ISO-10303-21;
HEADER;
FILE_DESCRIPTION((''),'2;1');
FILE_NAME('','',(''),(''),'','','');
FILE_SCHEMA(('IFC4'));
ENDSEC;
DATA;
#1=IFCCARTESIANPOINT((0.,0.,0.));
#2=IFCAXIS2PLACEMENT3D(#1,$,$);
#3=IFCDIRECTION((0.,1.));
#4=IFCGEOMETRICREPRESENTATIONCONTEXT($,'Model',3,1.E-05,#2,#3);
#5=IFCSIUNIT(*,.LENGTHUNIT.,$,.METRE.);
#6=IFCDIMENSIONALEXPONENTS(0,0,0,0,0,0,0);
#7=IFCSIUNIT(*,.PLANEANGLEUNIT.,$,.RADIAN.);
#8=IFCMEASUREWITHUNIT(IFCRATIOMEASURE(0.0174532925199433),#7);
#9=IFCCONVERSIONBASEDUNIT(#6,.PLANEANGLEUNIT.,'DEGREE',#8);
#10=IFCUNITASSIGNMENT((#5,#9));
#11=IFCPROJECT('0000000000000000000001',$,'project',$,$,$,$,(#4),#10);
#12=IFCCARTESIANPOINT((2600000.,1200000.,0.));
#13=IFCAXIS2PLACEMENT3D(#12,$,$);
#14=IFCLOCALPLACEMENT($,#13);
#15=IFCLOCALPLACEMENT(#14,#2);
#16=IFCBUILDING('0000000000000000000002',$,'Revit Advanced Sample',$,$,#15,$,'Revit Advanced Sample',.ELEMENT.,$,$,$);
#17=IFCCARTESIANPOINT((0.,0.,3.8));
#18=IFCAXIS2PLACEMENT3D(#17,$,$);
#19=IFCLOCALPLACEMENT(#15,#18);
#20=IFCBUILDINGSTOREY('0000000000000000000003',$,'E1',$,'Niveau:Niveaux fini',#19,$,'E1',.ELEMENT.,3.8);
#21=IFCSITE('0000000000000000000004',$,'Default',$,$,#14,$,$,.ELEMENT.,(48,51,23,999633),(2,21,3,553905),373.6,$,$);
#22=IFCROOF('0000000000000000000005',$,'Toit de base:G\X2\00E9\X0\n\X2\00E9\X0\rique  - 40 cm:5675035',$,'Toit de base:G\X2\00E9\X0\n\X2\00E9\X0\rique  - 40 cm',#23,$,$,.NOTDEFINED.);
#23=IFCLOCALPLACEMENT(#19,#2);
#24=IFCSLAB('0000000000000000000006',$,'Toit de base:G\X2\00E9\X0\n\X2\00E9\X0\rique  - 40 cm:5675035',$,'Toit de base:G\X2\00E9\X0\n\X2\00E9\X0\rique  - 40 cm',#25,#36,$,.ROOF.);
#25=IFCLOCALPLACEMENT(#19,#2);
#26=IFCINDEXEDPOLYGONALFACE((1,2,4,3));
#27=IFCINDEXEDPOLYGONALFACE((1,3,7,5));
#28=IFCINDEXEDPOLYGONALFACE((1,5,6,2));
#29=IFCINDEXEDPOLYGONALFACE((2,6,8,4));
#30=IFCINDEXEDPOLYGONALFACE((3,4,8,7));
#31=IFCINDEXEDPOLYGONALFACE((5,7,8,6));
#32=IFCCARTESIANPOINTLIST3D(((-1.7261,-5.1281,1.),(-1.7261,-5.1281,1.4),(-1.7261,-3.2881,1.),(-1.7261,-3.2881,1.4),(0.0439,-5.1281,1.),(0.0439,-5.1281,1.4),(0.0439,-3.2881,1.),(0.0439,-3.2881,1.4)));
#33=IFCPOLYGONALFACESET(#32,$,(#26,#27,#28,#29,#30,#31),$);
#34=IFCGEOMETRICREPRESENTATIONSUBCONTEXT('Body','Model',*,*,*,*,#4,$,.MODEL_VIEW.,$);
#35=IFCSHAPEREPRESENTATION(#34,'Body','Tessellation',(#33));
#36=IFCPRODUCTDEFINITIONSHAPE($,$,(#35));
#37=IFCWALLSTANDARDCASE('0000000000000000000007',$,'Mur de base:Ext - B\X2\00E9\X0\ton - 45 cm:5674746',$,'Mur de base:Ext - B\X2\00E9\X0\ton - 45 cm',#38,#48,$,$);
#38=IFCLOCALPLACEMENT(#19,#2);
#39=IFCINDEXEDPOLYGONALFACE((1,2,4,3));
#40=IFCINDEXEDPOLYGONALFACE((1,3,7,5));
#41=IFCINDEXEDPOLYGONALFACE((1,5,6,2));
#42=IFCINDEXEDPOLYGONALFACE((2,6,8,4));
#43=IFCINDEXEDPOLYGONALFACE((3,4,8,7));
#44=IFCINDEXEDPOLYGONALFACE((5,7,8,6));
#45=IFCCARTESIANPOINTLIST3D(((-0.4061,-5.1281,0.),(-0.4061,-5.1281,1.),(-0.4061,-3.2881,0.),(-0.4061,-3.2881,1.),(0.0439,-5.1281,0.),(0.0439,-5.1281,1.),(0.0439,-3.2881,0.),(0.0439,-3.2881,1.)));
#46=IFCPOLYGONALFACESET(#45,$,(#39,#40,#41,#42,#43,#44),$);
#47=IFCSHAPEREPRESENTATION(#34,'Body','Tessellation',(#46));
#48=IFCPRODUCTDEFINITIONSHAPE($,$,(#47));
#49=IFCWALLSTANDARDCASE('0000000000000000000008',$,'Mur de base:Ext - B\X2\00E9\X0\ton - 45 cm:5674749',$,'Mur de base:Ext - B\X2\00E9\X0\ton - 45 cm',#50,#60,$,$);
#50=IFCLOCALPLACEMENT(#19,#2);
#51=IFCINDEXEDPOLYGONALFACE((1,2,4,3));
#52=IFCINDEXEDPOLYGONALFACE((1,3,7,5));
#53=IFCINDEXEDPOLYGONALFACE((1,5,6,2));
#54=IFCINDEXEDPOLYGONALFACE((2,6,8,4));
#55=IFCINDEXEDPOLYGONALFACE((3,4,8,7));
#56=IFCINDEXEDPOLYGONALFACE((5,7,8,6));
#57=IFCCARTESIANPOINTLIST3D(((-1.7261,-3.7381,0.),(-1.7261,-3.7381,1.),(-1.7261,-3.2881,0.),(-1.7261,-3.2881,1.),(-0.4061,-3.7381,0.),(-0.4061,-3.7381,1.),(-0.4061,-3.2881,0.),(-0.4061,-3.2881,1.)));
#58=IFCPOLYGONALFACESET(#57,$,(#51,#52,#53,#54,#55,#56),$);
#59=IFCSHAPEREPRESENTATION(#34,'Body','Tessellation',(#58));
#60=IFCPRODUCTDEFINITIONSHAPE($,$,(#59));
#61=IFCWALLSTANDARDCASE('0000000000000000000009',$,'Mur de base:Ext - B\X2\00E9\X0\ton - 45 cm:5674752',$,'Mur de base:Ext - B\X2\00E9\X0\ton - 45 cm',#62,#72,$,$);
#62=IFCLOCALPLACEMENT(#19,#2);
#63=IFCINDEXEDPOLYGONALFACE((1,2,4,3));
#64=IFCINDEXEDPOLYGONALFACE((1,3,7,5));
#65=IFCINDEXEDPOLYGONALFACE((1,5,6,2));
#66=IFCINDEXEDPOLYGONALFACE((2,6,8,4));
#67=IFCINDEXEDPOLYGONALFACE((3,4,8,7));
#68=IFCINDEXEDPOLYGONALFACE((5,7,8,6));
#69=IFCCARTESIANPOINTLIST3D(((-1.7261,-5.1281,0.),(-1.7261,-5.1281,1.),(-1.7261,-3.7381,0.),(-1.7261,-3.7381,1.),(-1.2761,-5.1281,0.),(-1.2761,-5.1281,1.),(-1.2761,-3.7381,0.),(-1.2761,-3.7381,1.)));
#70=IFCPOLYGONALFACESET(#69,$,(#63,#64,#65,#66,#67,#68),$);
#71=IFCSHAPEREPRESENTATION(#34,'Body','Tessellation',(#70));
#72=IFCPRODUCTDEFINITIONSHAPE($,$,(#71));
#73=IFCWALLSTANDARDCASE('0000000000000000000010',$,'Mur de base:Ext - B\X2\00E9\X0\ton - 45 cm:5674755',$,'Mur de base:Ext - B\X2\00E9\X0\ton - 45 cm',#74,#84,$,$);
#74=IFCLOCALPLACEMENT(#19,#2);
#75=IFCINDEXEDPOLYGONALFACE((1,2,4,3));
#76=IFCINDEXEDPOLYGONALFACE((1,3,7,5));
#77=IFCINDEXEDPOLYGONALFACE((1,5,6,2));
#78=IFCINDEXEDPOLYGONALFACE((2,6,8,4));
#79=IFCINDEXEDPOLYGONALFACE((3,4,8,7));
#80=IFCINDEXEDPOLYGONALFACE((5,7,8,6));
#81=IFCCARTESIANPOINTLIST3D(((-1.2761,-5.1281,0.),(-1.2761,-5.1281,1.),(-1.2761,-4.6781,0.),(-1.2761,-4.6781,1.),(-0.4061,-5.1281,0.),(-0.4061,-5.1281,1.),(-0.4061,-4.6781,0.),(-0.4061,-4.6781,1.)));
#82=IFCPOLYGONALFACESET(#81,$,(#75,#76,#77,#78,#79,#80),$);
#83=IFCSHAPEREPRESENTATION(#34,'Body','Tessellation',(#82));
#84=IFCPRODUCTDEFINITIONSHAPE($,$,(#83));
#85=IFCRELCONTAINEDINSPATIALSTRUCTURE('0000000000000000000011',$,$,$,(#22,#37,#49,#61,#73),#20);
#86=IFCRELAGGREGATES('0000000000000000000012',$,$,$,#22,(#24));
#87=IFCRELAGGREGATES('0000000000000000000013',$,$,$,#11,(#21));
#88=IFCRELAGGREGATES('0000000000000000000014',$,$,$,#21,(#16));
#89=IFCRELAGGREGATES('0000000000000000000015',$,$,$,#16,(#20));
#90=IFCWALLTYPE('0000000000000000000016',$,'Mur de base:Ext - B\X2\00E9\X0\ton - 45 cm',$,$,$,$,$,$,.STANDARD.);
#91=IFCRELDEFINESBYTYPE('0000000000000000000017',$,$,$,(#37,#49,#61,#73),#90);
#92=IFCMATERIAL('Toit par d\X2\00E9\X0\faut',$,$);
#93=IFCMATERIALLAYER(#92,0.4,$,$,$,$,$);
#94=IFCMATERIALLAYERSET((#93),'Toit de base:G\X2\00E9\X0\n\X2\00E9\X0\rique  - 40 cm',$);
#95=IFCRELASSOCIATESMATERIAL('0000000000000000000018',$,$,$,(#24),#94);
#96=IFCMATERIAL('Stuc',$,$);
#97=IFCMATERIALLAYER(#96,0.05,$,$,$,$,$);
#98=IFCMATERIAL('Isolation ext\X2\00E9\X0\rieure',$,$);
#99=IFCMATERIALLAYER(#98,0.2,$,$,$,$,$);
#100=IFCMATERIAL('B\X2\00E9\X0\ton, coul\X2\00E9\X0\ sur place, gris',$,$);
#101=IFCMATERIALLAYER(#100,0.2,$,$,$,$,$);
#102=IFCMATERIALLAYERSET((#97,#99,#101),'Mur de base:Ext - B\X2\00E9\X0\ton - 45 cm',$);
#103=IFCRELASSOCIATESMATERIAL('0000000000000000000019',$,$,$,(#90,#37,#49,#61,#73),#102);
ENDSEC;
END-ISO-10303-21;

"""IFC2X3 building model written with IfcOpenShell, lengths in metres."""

from ifc_helpers import new_model, entity, si_unit, converted_unit, direction, frame, frame_2d, origin, place, context, subcontext, project, spatial, rectangle, extrude, material, layer, layer_set, layer_usage, type_object, element, aggregate, save


model = new_model("IFC2X3")

# Units and contexts
model_context = context("Model", 3, precision=1e-05, world=origin(), true_north=direction((0.0, 1.0)))
body_context = subcontext(model_context, "Body", "Model", "MODEL_VIEW")
ifc_project = project(units=[si_unit("LENGTHUNIT", "METRE"), converted_unit("PLANEANGLEUNIT", "DEGREE", entity("IfcRatioMeasure", 0.0174532925199433), si_unit("PLANEANGLEUNIT", "RADIAN"), dimensions=[0, 0, 0, 0, 0, 0, 0])], contexts=[model_context])

# Site, building, storey
site_placement = place(None, frame((2600000.0, 1200000.0, 0.0)))
site = spatial("IfcSite", under=ifc_project, at=site_placement, Name="Default", CompositionType="ELEMENT", RefLatitude=(48, 51, 23, 999633), RefLongitude=(2, 21, 3, 553905), RefElevation=373.6)
building_placement = place(site_placement, origin())
building = spatial("IfcBuilding", under=site, at=building_placement, Name="Revit Advanced Sample", LongName="Revit Advanced Sample", CompositionType="ELEMENT")
storey_placement = place(building_placement, frame((0.0, 0.0, 3.8)))
storey = spatial("IfcBuildingStorey", under=building, at=storey_placement, Name="E1", ObjectType="Niveau:Niveaux fini", LongName="E1", CompositionType="ELEMENT", Elevation=3.8)

# Roof, slab
roof_1_placement = place(storey_placement, frame((-1.7261, -5.1281, 1.0)))
roof_1 = element("IfcRoof", 1, at=roof_1_placement, inside=storey, Name="Toit de base:Générique  - 40 cm:5675035", ObjectType="Toit de base:Générique  - 40 cm", ShapeType="NOTDEFINED")
ifc_material_1 = material(Name="Toit par défaut")
ifc_layer_1 = layer(ifc_material_1, 0.4)
ifc_layer_set_1 = layer_set([ifc_layer_1], Name="Toit de base:Générique  - 40 cm")
slab_1_placement = place(roof_1_placement, origin())
slab_1 = element("IfcSlab", 2, at=slab_1_placement, material=ifc_layer_set_1, Name="Toit de base:Générique  - 40 cm:5675035", ObjectType="Toit de base:Générique  - 40 cm", PredefinedType="ROOF", context=body_context, shape_type="SweptSolid", body=[
    extrude(rectangle(XDim=1.84, YDim=1.77, at=frame_2d((0.0, 0.0), x_axis=(0.0, -1.0))), frame((0.885, 0.92, 0.0)), (0.0, 0.0, 1.0), 0.4),
])
aggregate(roof_1, [slab_1])

# Walls
ifc_material_2 = material(Name="Stuc")
ifc_layer_2 = layer(ifc_material_2, 0.05)
ifc_material_3 = material(Name="Isolation extérieure")
ifc_layer_3 = layer(ifc_material_3, 0.2)
ifc_material_4 = material(Name="Béton, coulé sur place, gris")
ifc_layer_4 = layer(ifc_material_4, 0.2)
ifc_layer_set_2 = layer_set([ifc_layer_2, ifc_layer_3, ifc_layer_4], Name="Mur de base:Ext - Béton - 45 cm")
ifc_layer_usage_1 = layer_usage(ifc_layer_set_2, "AXIS2", "NEGATIVE", 0.225)
wall_type = type_object("IfcWallType", Name="Mur de base:Ext - Béton - 45 cm", PredefinedType="STANDARD", material=ifc_layer_set_2)
wall_1_placement = place(storey_placement, frame((-0.1811, -5.1281, 0.0), z_axis=(0.0, 0.0, 1.0), x_axis=(0.0, 1.0, 0.0)))
element("IfcWallStandardCase", 3, at=wall_1_placement, inside=storey, type_object=wall_type, material=ifc_layer_usage_1, Name="Mur de base:Ext - Béton - 45 cm:5674746", ObjectType="Mur de base:Ext - Béton - 45 cm", context=body_context, shape_type="SweptSolid", body=[
    extrude(rectangle(XDim=1.84, YDim=0.45, at=frame_2d((0.92, 0.0), x_axis=(-1.0, 0.0))), origin(), (0.0, 0.0, 1.0), 1.0),
])
ifc_layer_usage_2 = layer_usage(ifc_layer_set_2, "AXIS2", "NEGATIVE", 0.225)
wall_2_placement = place(storey_placement, frame((-0.4061, -3.5131, 0.0), z_axis=(0.0, 0.0, 1.0), x_axis=(-1.0, 0.0, 0.0)))
element("IfcWallStandardCase", 4, at=wall_2_placement, inside=storey, type_object=wall_type, material=ifc_layer_usage_2, Name="Mur de base:Ext - Béton - 45 cm:5674749", ObjectType="Mur de base:Ext - Béton - 45 cm", context=body_context, shape_type="SweptSolid", body=[
    extrude(rectangle(XDim=1.32, YDim=0.45, at=frame_2d((0.66, 0.0), x_axis=(-1.0, 0.0))), origin(), (0.0, 0.0, 1.0), 1.0),
])
ifc_layer_usage_3 = layer_usage(ifc_layer_set_2, "AXIS2", "NEGATIVE", 0.225)
wall_3_placement = place(storey_placement, frame((-1.5011, -3.7381, 0.0), z_axis=(0.0, 0.0, 1.0), x_axis=(0.0, -1.0, 0.0)))
element("IfcWallStandardCase", 5, at=wall_3_placement, inside=storey, type_object=wall_type, material=ifc_layer_usage_3, Name="Mur de base:Ext - Béton - 45 cm:5674752", ObjectType="Mur de base:Ext - Béton - 45 cm", context=body_context, shape_type="SweptSolid", body=[
    extrude(rectangle(XDim=1.39, YDim=0.45, at=frame_2d((0.695, 0.0), x_axis=(-1.0, 0.0))), origin(), (0.0, 0.0, 1.0), 1.0),
])
ifc_layer_usage_4 = layer_usage(ifc_layer_set_2, "AXIS2", "NEGATIVE", 0.225)
wall_4_placement = place(storey_placement, frame((-1.2761, -4.9031, 0.0)))
element("IfcWallStandardCase", 6, at=wall_4_placement, inside=storey, type_object=wall_type, material=ifc_layer_usage_4, Name="Mur de base:Ext - Béton - 45 cm:5674755", ObjectType="Mur de base:Ext - Béton - 45 cm", context=body_context, shape_type="SweptSolid", body=[
    extrude(rectangle(XDim=0.87, YDim=0.45, at=frame_2d((0.435, 0.0), x_axis=(-1.0, 0.0))), origin(), (0.0, 0.0, 1.0), 1.0),
])

save(model, "model.ifc")
